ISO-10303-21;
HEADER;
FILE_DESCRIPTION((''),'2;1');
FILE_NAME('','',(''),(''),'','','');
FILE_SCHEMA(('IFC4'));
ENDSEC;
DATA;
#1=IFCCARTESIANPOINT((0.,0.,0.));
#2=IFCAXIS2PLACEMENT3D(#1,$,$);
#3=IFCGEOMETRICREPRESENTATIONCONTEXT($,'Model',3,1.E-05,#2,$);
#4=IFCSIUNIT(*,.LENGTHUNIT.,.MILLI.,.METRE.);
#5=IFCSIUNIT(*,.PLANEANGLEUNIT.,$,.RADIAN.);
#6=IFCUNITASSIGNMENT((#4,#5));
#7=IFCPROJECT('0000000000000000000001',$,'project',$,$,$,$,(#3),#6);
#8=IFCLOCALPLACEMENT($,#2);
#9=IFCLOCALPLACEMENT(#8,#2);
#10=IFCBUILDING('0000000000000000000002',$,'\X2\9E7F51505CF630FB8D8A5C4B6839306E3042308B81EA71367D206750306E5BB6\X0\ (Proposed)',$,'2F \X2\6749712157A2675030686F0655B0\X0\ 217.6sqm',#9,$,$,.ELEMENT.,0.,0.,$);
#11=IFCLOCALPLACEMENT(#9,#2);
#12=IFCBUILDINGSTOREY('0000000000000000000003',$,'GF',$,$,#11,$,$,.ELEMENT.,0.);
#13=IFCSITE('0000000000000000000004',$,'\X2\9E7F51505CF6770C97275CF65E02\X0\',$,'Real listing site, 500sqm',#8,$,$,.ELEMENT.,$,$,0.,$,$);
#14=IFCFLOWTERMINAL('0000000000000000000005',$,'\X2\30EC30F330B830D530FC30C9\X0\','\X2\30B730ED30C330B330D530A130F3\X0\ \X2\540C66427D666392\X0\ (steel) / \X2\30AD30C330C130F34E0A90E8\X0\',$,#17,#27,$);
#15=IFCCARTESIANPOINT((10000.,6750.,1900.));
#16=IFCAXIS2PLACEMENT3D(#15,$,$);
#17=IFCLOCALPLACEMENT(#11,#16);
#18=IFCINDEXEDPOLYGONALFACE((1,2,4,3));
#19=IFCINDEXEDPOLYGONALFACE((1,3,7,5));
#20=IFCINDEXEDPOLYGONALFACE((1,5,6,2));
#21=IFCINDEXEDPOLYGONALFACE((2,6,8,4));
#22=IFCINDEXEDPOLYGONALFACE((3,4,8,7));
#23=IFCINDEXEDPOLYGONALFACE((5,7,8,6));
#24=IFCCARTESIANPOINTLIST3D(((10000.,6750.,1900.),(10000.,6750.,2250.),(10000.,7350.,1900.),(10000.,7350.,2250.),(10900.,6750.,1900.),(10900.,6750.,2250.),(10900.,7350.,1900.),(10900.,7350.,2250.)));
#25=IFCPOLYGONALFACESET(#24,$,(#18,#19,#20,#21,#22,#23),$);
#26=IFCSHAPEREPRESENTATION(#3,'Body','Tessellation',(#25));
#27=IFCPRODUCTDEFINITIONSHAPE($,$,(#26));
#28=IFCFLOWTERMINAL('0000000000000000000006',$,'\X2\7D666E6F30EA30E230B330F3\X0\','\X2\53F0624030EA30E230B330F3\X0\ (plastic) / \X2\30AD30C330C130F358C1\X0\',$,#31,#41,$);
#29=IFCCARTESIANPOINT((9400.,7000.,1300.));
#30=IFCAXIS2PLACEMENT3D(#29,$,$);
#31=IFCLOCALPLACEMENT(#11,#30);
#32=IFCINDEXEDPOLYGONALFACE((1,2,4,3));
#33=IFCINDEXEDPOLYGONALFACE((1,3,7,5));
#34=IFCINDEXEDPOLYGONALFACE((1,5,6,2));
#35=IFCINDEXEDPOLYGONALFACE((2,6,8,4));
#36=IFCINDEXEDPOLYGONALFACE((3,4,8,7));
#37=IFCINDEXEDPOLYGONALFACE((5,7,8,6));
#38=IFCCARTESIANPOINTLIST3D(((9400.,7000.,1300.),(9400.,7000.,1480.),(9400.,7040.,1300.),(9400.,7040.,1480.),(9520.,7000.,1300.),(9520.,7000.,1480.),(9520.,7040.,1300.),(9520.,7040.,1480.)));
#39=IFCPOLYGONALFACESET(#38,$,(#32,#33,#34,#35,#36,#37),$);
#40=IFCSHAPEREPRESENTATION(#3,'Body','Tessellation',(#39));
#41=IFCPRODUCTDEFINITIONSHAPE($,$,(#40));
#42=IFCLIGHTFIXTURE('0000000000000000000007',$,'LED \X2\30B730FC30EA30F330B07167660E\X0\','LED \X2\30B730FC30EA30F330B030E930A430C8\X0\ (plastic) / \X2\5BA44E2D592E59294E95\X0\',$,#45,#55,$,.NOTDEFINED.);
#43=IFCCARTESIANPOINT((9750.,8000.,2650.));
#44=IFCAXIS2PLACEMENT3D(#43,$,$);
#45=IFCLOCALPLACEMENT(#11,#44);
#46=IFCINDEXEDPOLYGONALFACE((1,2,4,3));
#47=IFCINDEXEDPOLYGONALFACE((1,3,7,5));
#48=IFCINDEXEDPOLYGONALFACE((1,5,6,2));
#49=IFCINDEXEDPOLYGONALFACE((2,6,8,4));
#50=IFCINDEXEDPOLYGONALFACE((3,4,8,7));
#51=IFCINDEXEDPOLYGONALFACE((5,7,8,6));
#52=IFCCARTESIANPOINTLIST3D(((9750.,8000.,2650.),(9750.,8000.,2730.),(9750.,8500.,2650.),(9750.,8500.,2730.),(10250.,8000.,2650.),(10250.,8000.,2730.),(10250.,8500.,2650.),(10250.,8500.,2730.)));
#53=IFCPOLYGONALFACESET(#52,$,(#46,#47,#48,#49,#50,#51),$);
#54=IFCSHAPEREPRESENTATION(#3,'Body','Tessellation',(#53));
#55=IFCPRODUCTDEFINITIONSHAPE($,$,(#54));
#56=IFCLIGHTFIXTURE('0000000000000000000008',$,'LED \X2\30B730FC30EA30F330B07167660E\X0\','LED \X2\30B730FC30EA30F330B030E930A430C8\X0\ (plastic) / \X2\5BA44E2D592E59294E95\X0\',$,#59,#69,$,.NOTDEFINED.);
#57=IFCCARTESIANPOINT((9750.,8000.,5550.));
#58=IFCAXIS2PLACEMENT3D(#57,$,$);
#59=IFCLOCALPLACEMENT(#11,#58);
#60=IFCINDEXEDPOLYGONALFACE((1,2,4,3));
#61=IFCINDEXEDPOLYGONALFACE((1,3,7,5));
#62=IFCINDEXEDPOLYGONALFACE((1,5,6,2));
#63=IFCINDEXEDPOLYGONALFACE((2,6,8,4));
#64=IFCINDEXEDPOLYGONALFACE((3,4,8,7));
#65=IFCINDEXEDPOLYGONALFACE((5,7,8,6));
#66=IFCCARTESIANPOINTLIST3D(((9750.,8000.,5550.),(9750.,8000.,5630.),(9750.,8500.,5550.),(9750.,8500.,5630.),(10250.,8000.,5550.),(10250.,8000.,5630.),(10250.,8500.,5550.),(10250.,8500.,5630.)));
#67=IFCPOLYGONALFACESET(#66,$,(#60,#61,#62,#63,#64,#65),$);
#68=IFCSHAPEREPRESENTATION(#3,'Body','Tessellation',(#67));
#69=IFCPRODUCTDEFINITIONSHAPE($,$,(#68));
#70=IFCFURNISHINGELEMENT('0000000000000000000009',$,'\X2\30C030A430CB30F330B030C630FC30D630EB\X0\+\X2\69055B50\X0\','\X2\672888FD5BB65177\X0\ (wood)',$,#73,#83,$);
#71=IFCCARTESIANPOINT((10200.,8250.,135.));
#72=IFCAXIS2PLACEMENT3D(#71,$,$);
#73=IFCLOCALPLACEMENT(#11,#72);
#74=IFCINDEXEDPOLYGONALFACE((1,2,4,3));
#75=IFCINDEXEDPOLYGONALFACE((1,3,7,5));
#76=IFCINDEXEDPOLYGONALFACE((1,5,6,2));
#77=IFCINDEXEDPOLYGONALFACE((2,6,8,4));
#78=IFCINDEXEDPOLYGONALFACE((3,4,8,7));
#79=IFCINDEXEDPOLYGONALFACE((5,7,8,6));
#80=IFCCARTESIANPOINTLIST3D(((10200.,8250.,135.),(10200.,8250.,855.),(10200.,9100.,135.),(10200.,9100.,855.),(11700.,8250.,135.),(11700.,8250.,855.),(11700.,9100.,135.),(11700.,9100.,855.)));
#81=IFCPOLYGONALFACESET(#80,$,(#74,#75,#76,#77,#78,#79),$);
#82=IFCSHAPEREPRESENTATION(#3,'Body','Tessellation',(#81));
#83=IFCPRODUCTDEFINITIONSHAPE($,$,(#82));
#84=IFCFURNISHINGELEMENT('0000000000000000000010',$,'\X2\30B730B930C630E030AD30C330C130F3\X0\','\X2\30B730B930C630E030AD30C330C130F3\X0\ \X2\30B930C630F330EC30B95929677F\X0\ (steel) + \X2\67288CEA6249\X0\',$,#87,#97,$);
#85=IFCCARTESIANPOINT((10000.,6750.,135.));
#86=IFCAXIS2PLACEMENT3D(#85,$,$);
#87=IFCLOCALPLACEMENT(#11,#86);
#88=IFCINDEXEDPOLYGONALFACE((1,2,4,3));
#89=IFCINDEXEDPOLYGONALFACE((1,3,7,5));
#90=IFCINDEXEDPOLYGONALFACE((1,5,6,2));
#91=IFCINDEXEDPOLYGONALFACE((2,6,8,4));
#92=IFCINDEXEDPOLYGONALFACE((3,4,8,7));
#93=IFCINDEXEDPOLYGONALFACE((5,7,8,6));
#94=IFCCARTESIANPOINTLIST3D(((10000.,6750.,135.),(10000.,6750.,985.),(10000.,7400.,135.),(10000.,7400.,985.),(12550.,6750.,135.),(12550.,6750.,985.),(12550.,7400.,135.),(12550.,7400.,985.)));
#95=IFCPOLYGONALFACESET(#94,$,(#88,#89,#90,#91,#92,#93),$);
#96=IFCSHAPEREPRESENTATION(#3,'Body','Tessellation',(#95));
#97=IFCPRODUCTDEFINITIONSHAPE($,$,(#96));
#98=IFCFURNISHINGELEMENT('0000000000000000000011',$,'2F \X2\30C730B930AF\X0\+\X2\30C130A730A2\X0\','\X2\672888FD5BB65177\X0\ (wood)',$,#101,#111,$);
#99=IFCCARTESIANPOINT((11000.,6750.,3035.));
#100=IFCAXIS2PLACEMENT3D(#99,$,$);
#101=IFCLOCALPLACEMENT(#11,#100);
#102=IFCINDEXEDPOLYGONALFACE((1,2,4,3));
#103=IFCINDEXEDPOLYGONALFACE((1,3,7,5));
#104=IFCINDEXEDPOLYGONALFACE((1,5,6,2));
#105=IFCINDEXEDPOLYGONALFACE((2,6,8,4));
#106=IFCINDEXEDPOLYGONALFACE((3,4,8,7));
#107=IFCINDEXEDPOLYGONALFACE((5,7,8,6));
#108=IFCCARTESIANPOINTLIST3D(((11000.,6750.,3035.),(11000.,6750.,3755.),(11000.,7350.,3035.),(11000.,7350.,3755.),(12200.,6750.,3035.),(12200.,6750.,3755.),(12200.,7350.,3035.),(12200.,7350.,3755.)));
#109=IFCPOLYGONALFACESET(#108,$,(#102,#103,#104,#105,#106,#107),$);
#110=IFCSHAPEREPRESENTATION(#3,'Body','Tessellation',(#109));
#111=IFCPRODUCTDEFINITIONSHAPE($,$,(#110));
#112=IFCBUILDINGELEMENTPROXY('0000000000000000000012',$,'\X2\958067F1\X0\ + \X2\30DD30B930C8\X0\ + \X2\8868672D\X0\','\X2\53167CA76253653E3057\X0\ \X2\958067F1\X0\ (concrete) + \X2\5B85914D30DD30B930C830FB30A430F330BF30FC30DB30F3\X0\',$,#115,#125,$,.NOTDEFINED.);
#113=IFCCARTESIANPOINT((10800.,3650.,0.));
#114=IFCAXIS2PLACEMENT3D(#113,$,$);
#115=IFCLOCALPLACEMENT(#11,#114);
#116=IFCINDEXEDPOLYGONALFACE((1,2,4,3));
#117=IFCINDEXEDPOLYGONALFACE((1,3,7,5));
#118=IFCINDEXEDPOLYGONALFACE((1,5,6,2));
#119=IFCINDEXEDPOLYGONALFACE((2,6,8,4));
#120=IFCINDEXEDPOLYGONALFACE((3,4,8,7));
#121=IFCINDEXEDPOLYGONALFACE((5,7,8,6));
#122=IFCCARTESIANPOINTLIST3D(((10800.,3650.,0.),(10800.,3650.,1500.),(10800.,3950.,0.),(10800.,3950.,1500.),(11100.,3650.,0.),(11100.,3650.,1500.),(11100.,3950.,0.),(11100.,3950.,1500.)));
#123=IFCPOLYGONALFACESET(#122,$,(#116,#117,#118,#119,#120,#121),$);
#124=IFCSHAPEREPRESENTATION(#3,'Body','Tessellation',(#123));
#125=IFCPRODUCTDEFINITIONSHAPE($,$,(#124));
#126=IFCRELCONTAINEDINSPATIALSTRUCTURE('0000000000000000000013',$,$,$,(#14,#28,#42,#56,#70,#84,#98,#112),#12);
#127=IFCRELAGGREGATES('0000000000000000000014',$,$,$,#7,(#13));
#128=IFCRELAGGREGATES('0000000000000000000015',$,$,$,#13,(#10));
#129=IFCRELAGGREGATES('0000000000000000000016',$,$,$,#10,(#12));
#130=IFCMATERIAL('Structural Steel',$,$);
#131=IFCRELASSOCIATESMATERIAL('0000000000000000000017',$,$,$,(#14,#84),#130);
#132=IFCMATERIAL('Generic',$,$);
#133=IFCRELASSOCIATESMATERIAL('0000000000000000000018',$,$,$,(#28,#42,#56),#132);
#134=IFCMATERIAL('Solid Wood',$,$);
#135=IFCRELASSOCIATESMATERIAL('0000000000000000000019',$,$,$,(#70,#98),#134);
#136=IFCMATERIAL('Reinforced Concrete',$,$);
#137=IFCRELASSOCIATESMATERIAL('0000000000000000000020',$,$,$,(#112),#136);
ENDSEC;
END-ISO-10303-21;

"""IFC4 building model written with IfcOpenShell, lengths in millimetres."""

from ifc_helpers import new_model, si_unit, frame, frame_2d, origin, place, context, project, spatial, rectangle, extrude, material, element, save


model = new_model("IFC4")

# Units and contexts
model_context = context("Model", 3, precision=1e-05, world=origin())
ifc_project = project(units=[si_unit("LENGTHUNIT", "METRE", prefix="MILLI"), si_unit("PLANEANGLEUNIT", "RADIAN")], contexts=[model_context])

# Site, building, storey
site_placement = place(None, origin())
site = spatial("IfcSite", under=ifc_project, at=site_placement, Name="鹿児島県霧島市", ObjectType="Real listing site, 500sqm", CompositionType="ELEMENT", RefElevation=0.0)
building_placement = place(site_placement, origin())
building = spatial("IfcBuilding", under=site, at=building_placement, Name="鹿児島・越屋根のある自然素材の家 (Proposed)", ObjectType="2F 杉無垢材と漆喰 217.6sqm", CompositionType="ELEMENT", ElevationOfRefHeight=0.0, ElevationOfTerrain=0.0)
storey_placement = place(building_placement, origin())
storey = spatial("IfcBuildingStorey", under=building, at=storey_placement, Name="GF", CompositionType="ELEMENT", Elevation=0.0)

# Shared definitions
ifc_material_1 = material(Name="Solid Wood")

# Shared definitions
ifc_material_2 = material(Name="Structural Steel")

# Shared definitions
ifc_material_3 = material(Name="Reinforced Concrete")

# Flow terminals
flow_terminal_1_placement = place(storey_placement, frame((10000.0, 6750.0, 1900.0)))
element("IfcFlowTerminal", 1, at=flow_terminal_1_placement, inside=storey, material=ifc_material_2, Name="レンジフード", Description="シロッコファン 同時給排 (steel) / キッチン上部", context=model_context, shape_type="SweptSolid", body=[
    extrude(rectangle(XDim=900.0, YDim=600.0, at=frame_2d((450.0, 300.0))), frame((10000.0, 6750.0, 1900.0)), (0.0, 0.0, 1.0), 350.0),
])
ifc_material_4 = material(Name="Generic")
flow_terminal_2_placement = place(storey_placement, frame((9400.0, 7000.0, 1300.0)))
element("IfcFlowTerminal", 2, at=flow_terminal_2_placement, inside=storey, material=ifc_material_4, Name="給湯リモコン", Description="台所リモコン (plastic) / キッチン壁", context=model_context, shape_type="SweptSolid", body=[
    extrude(rectangle(XDim=120.0, YDim=40.0, at=frame_2d((60.0, 20.0))), frame((9400.0, 7000.0, 1300.0)), (0.0, 0.0, 1.0), 180.0),
])

# Light fixtures
light_fixture_1_placement = place(storey_placement, frame((9750.0, 8000.0, 2650.0)))
element("IfcLightFixture", 3, at=light_fixture_1_placement, inside=storey, material=ifc_material_4, Name="LED シーリング照明", Description="LED シーリングライト (plastic) / 室中央天井", PredefinedType="NOTDEFINED", context=model_context, shape_type="SweptSolid", body=[
    extrude(rectangle(XDim=500.0, YDim=500.0, at=frame_2d((250.0, 250.0))), frame((9750.0, 8000.0, 2650.0)), (0.0, 0.0, 1.0), 80.0),
])
light_fixture_2_placement = place(storey_placement, frame((9750.0, 8000.0, 5550.0)))
element("IfcLightFixture", 4, at=light_fixture_2_placement, inside=storey, material=ifc_material_4, Name="LED シーリング照明", Description="LED シーリングライト (plastic) / 室中央天井", PredefinedType="NOTDEFINED", context=model_context, shape_type="SweptSolid", body=[
    extrude(rectangle(XDim=500.0, YDim=500.0, at=frame_2d((250.0, 250.0))), frame((9750.0, 8000.0, 5550.0)), (0.0, 0.0, 1.0), 80.0),
])

# Furnishing elements
furnishing_1_placement = place(storey_placement, frame((10200.0, 8250.0, 135.0)))
element("IfcFurnishingElement", 5, at=furnishing_1_placement, inside=storey, material=ifc_material_1, Name="ダイニングテーブル+椅子", Description="木製家具 (wood)", context=model_context, shape_type="SweptSolid", body=[
    extrude(rectangle(XDim=1500.0, YDim=850.0, at=frame_2d((750.0, 425.0))), frame((10200.0, 8250.0, 135.0)), (0.0, 0.0, 1.0), 720.0),
])
furnishing_2_placement = place(storey_placement, frame((10000.0, 6750.0, 135.0)))
element("IfcFurnishingElement", 6, at=furnishing_2_placement, inside=storey, material=ifc_material_2, Name="システムキッチン", Description="システムキッチン ステンレス天板 (steel) + 木質扉", context=model_context, shape_type="SweptSolid", body=[
    extrude(rectangle(XDim=2550.0, YDim=650.0, at=frame_2d((1275.0, 325.0))), frame((10000.0, 6750.0, 135.0)), (0.0, 0.0, 1.0), 850.0),
])
furnishing_3_placement = place(storey_placement, frame((11000.0, 6750.0, 3035.0)))
element("IfcFurnishingElement", 7, at=furnishing_3_placement, inside=storey, material=ifc_material_1, Name="2F デスク+チェア", Description="木製家具 (wood)", context=model_context, shape_type="SweptSolid", body=[
    extrude(rectangle(XDim=1200.0, YDim=600.0, at=frame_2d((600.0, 300.0))), frame((11000.0, 6750.0, 3035.0)), (0.0, 0.0, 1.0), 720.0),
])

# Building element proxy
proxy_placement = place(storey_placement, frame((10800.0, 3650.0, 0.0)))
element("IfcBuildingElementProxy", 8, at=proxy_placement, inside=storey, material=ifc_material_3, Name="門柱 + ポスト + 表札", Description="化粧打放し 門柱 (concrete) + 宅配ポスト・インターホン", PredefinedType="NOTDEFINED", context=model_context, shape_type="SweptSolid", body=[
    extrude(rectangle(XDim=300.0, YDim=300.0, at=frame_2d((150.0, 150.0))), frame((10800.0, 3650.0, 0.0)), (0.0, 0.0, 1.0), 1500.0),
])

save(model, "model.ifc")
